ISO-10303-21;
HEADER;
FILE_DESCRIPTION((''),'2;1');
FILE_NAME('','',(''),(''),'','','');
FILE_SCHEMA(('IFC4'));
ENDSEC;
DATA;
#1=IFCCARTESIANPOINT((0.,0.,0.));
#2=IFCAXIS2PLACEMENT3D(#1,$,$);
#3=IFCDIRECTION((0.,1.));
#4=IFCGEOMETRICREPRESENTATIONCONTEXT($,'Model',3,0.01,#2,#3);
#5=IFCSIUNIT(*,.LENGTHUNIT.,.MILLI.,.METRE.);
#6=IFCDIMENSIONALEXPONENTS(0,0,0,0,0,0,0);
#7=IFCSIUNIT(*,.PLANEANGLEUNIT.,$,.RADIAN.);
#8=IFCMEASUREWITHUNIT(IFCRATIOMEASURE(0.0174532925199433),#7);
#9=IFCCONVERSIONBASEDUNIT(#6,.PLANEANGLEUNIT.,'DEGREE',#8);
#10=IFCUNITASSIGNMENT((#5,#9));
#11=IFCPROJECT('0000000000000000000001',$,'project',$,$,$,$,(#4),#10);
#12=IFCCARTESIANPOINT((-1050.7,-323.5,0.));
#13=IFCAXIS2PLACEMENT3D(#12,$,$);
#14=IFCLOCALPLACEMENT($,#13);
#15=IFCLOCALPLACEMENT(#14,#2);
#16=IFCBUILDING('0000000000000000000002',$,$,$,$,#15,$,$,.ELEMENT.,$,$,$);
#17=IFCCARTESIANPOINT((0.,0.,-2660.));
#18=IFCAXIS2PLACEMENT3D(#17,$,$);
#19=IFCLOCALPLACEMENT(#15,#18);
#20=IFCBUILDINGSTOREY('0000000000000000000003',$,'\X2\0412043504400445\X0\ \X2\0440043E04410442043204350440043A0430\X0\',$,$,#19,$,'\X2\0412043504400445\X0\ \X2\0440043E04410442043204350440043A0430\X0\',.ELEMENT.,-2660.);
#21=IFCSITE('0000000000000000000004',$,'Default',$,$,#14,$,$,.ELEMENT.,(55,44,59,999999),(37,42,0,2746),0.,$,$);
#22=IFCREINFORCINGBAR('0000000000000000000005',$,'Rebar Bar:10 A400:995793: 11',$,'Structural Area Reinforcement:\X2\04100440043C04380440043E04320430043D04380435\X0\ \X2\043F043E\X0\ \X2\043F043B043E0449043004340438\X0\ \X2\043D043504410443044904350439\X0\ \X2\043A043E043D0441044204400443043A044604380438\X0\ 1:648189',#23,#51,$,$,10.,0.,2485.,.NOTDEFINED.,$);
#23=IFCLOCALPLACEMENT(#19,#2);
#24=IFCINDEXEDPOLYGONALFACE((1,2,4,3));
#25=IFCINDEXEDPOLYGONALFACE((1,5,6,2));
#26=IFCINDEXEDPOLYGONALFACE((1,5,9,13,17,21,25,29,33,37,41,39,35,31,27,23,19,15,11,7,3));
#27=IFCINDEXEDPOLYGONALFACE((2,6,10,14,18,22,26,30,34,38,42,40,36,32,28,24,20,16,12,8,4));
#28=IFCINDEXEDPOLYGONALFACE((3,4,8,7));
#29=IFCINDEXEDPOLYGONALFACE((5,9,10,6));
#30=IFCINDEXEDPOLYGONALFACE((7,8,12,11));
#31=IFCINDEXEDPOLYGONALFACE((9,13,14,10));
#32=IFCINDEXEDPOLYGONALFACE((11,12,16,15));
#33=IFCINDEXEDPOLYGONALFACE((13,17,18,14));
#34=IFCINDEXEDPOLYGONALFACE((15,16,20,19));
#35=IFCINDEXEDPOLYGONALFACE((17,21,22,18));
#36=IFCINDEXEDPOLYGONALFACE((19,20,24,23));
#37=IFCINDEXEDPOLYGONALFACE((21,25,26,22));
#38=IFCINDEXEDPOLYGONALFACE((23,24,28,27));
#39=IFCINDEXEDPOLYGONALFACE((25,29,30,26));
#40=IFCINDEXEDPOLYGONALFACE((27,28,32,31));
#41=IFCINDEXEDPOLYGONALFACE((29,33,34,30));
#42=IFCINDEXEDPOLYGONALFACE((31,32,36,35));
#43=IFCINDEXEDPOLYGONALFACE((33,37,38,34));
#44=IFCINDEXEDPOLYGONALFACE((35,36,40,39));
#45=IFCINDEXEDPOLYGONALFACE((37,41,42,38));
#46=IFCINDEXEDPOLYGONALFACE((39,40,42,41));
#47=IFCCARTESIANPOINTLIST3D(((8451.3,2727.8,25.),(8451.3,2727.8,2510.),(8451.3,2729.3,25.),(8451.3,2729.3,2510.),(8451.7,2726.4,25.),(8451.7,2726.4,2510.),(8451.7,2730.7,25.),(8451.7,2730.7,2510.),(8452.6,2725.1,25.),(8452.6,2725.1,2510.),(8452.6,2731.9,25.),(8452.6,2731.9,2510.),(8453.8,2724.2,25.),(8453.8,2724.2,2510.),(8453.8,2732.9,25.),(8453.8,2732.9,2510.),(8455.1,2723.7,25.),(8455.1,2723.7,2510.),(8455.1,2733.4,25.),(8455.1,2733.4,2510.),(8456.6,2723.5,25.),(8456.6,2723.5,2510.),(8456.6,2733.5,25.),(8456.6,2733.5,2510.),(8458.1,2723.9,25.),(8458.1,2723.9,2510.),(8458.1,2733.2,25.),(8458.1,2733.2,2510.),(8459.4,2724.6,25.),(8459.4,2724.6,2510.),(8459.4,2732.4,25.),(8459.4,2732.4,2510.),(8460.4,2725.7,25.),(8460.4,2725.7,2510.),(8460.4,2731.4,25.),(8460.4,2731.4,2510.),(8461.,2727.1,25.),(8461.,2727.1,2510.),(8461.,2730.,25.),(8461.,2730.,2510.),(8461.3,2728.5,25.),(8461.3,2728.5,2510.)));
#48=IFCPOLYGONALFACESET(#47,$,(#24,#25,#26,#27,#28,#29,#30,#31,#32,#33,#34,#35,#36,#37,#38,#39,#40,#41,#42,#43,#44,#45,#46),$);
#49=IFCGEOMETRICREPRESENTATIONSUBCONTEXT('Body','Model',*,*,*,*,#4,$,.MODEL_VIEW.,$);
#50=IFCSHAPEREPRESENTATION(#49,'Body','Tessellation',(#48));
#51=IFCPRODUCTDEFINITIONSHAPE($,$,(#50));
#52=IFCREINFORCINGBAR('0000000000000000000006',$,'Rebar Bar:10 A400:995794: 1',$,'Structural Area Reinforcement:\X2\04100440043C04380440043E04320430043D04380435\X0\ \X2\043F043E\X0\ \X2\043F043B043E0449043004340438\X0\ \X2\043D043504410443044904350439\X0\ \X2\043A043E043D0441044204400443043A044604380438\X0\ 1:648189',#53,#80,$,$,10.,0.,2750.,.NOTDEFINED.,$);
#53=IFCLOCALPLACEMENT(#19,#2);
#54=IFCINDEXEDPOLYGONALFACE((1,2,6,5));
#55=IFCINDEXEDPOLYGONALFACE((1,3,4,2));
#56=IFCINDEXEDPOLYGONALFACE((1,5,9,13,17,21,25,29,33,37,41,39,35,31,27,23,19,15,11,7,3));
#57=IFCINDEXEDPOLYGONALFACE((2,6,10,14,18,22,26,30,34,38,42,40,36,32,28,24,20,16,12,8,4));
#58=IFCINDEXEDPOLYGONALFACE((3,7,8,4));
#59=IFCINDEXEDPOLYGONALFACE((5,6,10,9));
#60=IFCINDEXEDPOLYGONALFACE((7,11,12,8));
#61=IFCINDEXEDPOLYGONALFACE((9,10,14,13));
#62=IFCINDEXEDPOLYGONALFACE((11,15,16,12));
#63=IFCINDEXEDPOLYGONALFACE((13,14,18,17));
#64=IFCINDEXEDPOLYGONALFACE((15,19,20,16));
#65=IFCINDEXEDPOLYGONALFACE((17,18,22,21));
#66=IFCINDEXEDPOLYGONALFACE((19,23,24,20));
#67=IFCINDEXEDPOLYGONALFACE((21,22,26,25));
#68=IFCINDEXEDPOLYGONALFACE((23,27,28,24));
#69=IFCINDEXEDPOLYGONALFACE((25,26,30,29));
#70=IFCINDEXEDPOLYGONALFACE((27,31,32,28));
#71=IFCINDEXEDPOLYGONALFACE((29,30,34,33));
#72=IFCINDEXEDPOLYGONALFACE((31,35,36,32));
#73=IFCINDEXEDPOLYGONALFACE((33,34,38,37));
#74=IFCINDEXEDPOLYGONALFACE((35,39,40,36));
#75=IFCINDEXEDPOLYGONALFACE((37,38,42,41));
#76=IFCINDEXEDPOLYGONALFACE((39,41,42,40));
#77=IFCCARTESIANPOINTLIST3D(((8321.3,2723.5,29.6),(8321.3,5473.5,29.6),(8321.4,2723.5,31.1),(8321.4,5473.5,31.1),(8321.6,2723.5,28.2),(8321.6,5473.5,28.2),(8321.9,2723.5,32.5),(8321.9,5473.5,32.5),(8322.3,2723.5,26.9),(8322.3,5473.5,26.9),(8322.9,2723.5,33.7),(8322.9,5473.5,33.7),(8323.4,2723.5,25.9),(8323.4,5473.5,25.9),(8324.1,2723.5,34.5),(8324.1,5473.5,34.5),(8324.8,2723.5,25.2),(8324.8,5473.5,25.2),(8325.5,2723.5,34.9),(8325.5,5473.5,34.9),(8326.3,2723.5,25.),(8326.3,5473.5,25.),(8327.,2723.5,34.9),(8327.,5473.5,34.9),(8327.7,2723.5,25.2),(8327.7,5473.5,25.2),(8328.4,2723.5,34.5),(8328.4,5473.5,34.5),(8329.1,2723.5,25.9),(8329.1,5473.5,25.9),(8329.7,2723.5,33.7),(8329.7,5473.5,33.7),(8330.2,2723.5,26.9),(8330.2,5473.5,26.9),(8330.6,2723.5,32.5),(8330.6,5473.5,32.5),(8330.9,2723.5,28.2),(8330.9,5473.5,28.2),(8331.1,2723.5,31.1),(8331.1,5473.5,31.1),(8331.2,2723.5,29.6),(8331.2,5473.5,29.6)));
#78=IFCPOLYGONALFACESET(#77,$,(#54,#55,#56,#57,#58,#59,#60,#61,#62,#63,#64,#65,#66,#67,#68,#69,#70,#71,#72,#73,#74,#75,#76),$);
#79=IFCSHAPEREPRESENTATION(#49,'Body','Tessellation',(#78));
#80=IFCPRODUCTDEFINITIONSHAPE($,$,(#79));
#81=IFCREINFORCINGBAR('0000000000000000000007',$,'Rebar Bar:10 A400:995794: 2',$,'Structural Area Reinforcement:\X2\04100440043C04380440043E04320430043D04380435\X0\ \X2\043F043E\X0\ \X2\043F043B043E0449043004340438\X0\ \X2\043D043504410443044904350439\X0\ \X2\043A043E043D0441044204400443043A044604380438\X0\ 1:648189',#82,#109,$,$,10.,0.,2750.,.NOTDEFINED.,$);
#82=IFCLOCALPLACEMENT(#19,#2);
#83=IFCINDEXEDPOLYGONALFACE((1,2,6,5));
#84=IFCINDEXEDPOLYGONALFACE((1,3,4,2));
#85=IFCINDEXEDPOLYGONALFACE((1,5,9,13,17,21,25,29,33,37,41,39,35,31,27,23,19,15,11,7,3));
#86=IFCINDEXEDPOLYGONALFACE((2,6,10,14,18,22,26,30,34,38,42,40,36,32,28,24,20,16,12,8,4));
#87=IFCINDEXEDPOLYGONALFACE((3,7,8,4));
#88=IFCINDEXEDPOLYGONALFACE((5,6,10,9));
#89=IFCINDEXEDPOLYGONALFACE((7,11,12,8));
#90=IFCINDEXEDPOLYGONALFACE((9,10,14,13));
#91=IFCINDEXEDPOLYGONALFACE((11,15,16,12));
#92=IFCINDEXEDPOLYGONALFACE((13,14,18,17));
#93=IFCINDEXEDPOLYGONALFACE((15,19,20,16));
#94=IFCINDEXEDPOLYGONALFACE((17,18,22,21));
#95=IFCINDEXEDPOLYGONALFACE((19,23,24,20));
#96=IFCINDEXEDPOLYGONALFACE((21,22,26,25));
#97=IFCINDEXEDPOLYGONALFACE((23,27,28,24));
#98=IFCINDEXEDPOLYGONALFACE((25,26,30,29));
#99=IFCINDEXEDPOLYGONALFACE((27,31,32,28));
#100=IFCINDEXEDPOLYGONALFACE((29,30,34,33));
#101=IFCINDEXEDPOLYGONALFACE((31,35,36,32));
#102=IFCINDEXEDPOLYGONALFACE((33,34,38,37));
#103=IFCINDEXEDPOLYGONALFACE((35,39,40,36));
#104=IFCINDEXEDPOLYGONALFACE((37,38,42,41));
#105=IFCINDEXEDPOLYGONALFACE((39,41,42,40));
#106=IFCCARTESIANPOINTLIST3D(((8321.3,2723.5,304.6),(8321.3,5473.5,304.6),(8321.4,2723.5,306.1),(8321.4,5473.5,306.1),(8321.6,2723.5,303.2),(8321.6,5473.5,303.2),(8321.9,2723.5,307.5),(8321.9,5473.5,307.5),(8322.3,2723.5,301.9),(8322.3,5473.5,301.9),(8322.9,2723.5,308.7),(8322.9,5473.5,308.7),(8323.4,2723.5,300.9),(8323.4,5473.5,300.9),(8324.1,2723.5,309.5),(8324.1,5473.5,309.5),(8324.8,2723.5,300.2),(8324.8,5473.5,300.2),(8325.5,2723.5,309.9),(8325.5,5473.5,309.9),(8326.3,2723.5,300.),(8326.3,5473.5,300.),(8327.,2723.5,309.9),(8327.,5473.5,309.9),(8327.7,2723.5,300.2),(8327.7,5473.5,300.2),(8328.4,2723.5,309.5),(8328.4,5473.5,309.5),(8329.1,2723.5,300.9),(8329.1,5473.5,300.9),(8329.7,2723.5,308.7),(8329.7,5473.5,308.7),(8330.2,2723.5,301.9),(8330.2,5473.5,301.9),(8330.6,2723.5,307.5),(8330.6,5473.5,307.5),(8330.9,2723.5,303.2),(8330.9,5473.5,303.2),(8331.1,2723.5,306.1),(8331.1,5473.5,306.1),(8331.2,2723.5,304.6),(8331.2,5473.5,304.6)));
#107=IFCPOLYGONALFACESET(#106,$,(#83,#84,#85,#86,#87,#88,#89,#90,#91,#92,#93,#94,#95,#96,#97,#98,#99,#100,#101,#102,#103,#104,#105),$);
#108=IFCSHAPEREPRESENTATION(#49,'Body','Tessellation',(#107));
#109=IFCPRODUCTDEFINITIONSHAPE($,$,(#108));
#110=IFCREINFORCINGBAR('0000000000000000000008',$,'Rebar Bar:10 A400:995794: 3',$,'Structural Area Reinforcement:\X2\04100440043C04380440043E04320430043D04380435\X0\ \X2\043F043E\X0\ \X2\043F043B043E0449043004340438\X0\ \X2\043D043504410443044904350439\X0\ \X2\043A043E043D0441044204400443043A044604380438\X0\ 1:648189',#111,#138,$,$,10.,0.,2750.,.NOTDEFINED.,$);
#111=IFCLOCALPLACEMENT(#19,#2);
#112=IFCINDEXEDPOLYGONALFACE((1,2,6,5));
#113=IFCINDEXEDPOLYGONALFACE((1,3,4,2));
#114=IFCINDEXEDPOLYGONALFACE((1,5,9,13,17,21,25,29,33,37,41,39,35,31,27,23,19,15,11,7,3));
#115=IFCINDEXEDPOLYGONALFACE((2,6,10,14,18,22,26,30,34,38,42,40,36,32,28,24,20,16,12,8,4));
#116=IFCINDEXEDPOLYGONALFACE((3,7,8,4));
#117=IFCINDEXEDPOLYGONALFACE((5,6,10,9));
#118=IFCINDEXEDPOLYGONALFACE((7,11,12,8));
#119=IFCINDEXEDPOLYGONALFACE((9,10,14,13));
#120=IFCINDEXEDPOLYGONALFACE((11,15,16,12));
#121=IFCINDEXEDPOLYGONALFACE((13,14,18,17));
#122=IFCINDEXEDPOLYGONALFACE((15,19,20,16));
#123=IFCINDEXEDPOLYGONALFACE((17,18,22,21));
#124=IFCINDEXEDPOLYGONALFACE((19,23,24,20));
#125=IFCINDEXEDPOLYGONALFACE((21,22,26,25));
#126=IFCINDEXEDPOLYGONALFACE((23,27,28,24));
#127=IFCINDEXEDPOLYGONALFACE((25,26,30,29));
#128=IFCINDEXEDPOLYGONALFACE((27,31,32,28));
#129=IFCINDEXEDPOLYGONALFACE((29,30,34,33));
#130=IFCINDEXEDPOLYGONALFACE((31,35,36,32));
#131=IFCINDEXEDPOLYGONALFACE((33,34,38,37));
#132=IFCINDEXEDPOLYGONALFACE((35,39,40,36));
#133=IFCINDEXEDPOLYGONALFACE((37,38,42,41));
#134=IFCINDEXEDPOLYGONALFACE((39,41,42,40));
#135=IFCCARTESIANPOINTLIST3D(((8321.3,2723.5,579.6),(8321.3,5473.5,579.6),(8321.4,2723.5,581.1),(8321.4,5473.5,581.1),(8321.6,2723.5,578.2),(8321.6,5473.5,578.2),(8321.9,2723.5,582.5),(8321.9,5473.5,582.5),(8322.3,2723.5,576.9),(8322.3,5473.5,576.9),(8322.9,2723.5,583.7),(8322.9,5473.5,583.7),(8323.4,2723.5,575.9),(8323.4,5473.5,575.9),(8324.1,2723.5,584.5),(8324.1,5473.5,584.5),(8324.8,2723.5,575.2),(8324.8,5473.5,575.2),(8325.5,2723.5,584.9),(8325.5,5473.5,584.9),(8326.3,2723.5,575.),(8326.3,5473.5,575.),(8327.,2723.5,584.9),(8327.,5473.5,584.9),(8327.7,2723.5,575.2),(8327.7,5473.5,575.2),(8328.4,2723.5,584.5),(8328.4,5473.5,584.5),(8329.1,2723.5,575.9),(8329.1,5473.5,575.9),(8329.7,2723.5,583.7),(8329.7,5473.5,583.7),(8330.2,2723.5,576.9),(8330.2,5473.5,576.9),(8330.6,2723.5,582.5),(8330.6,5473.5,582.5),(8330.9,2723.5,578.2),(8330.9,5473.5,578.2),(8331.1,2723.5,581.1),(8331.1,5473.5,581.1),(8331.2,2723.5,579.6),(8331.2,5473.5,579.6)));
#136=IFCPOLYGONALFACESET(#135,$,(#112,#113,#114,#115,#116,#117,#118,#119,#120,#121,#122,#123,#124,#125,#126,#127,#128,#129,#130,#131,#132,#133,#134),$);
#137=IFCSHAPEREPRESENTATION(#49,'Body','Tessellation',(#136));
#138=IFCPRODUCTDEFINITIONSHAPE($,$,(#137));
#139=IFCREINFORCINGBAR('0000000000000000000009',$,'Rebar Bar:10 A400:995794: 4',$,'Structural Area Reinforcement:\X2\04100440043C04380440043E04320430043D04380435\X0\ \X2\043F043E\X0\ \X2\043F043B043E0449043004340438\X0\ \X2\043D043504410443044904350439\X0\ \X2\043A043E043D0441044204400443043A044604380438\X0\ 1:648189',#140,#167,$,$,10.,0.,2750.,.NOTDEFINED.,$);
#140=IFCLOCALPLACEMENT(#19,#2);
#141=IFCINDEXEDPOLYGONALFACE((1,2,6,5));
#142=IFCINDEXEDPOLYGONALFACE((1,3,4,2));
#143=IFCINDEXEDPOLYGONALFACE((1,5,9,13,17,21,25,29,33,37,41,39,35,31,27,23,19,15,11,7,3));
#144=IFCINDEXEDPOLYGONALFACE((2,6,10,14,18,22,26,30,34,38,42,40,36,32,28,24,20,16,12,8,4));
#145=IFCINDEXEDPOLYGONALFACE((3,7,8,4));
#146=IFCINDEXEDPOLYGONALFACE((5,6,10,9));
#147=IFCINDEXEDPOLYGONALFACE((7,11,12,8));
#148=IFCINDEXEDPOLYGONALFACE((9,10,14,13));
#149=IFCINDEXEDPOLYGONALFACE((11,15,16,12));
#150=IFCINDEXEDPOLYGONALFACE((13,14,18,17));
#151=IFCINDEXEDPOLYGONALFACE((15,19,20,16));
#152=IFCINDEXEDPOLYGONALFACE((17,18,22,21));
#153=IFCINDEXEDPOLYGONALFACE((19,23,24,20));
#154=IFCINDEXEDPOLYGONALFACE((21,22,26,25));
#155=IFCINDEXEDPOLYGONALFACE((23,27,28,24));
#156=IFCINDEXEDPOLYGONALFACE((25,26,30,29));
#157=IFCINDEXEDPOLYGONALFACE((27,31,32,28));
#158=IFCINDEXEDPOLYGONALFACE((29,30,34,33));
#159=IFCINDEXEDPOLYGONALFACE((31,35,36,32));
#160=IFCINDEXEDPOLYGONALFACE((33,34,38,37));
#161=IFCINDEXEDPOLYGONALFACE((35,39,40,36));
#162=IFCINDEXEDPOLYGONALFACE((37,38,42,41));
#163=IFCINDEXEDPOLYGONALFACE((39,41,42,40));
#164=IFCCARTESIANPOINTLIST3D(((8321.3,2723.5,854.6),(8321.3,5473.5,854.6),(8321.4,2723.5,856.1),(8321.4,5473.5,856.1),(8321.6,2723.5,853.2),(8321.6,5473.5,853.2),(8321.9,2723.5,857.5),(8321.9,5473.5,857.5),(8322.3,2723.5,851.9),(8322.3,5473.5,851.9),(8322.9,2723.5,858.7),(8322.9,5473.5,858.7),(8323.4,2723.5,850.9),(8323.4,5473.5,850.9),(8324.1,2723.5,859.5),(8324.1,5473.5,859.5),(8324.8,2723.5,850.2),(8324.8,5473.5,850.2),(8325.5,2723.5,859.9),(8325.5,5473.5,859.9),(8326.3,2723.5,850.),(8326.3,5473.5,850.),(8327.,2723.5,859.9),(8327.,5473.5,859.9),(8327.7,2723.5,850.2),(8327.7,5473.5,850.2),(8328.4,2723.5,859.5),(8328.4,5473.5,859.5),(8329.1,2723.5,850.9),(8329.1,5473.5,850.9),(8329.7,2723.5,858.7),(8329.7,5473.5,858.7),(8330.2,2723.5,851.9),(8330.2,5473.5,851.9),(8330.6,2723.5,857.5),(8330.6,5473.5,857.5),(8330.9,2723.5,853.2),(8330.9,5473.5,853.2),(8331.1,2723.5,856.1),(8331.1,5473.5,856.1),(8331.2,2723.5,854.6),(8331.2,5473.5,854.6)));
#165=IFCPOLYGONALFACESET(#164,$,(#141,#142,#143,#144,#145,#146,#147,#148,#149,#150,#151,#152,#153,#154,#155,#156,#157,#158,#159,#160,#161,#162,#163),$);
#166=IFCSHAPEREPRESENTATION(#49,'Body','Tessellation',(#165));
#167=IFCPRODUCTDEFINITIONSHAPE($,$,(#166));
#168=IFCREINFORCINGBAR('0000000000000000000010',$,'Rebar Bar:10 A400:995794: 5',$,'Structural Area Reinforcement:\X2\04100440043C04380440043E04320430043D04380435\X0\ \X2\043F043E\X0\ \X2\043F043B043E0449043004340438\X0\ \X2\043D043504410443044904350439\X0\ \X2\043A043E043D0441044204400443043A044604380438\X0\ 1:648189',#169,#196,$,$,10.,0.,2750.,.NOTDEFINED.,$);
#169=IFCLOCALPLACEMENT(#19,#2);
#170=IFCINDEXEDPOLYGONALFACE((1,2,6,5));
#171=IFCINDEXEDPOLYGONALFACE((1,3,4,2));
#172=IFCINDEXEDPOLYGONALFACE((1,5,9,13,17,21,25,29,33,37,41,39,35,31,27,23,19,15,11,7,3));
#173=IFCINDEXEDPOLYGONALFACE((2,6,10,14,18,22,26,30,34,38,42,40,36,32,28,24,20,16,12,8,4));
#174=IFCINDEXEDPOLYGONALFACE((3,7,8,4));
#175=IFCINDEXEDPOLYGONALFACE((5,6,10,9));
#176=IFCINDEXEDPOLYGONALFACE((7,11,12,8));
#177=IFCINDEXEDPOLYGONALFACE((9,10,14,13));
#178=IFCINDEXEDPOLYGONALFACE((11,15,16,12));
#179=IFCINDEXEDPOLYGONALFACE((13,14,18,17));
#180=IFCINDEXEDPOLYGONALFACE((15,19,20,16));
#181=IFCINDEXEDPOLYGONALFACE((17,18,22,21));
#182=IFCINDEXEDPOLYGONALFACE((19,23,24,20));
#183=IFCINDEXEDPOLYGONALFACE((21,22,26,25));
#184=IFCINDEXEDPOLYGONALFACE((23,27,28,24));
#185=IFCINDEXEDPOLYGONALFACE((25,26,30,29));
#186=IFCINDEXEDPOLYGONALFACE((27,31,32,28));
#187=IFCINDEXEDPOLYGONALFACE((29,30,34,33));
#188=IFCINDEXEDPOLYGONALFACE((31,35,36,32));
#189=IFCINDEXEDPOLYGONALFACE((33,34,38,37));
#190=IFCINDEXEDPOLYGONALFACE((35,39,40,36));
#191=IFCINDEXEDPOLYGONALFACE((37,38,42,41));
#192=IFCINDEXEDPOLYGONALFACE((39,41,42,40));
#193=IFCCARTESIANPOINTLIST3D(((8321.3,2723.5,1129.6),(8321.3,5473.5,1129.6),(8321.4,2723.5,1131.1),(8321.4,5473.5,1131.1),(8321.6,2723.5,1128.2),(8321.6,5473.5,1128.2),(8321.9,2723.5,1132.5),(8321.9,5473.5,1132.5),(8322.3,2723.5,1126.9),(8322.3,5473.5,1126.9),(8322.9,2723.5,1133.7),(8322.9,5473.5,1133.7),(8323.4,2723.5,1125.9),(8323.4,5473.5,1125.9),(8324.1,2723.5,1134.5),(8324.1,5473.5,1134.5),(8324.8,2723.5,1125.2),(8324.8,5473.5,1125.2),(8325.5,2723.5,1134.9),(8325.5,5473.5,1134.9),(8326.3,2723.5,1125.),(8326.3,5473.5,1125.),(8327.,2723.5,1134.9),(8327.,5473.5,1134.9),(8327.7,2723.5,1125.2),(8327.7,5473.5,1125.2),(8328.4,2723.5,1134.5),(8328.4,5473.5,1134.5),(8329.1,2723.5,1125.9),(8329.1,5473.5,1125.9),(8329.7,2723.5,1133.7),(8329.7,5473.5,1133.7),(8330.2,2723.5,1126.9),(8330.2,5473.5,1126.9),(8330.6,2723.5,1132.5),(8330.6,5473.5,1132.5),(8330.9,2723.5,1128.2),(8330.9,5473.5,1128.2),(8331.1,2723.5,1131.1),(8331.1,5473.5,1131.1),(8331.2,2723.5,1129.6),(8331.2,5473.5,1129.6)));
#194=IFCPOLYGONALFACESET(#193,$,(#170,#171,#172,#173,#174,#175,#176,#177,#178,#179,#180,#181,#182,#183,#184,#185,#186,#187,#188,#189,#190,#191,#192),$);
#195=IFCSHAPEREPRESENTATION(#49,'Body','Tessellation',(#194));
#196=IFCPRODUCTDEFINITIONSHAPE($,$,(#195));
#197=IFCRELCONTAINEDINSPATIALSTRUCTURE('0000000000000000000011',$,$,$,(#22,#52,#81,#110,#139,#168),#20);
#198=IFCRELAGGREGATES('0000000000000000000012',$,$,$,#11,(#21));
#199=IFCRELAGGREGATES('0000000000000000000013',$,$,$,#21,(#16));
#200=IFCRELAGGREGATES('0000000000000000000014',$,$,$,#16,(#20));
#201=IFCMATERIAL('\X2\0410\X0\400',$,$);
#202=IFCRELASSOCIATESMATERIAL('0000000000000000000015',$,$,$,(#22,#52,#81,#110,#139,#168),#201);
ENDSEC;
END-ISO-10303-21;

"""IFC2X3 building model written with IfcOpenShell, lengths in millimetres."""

from ifc_helpers import new_model, entity, si_unit, converted_unit, direction, frame, origin, place, context, subcontext, project, spatial, material, element, save


model = new_model("IFC2X3")

# Units and contexts
model_context = context("Model", 3, precision=0.01, world=origin(), true_north=direction((0.0, 1.0)))
body_context = subcontext(model_context, "Body", "Model", "MODEL_VIEW")
ifc_project = project(units=[si_unit("LENGTHUNIT", "METRE", prefix="MILLI"), converted_unit("PLANEANGLEUNIT", "DEGREE", entity("IfcRatioMeasure", 0.0174532925199433), si_unit("PLANEANGLEUNIT", "RADIAN"), dimensions=[0, 0, 0, 0, 0, 0, 0])], contexts=[model_context])

# Site, building, storey
site_placement = place(None, frame((-1050.7, -323.5, 0.0)))
site = spatial("IfcSite", under=ifc_project, at=site_placement, Name="Default", CompositionType="ELEMENT", RefLatitude=(55, 44, 59, 999999), RefLongitude=(37, 42, 0, 2746), RefElevation=0.0)
building_placement = place(site_placement, origin())
building = spatial("IfcBuilding", under=site, at=building_placement, CompositionType="ELEMENT")
storey_placement = place(building_placement, frame((0.0, 0.0, -2660.0)))
storey = spatial("IfcBuildingStorey", under=building, at=storey_placement, Name="Верх ростверка", LongName="Верх ростверка", CompositionType="ELEMENT", Elevation=-2660.0)

# Reinforcing bars
ifc_material = material(Name="А400")
reinforcing_bar_1_placement = place(storey_placement, origin())
element("IfcReinforcingBar", 1, at=reinforcing_bar_1_placement, inside=storey, material=ifc_material, Name="Rebar Bar:10 A400:995793: 11", ObjectType="Structural Area Reinforcement:Армирование по площади несущей конструкции 1:648189", BarLength=2485.0, BarRole="NOTDEFINED", CrossSectionArea=0.0, NominalDiameter=10.0, context=body_context, shape_type="AdvancedSweptSolid", body=[
    entity("IfcSweptDiskSolid", entity("IfcCompositeCurve", [entity("IfcCompositeCurveSegment", "CONTINUOUS", True, entity("IfcPolyline", [entity("IfcCartesianPoint", [8456.3, 2728.5, 25.0]), entity("IfcCartesianPoint", [8456.3, 2728.5, 2510.0])]))], False), 5.0, None, 0.0, 1.0),
])
reinforcing_bar_2_placement = place(storey_placement, origin())
element("IfcReinforcingBar", 2, at=reinforcing_bar_2_placement, inside=storey, material=ifc_material, Name="Rebar Bar:10 A400:995794: 1", ObjectType="Structural Area Reinforcement:Армирование по площади несущей конструкции 1:648189", BarLength=2750.0, BarRole="NOTDEFINED", CrossSectionArea=0.0, NominalDiameter=10.0, context=body_context, shape_type="AdvancedSweptSolid", body=[
    entity("IfcSweptDiskSolid", entity("IfcCompositeCurve", [entity("IfcCompositeCurveSegment", "CONTINUOUS", True, entity("IfcPolyline", [entity("IfcCartesianPoint", [8326.3, 5473.5, 30.0]), entity("IfcCartesianPoint", [8326.3, 2723.5, 30.0])]))], False), 5.0, None, 0.0, 1.0),
])
reinforcing_bar_3_placement = place(storey_placement, origin())
element("IfcReinforcingBar", 3, at=reinforcing_bar_3_placement, inside=storey, material=ifc_material, Name="Rebar Bar:10 A400:995794: 2", ObjectType="Structural Area Reinforcement:Армирование по площади несущей конструкции 1:648189", BarLength=2750.0, BarRole="NOTDEFINED", CrossSectionArea=0.0, NominalDiameter=10.0, context=body_context, shape_type="AdvancedSweptSolid", body=[
    entity("IfcSweptDiskSolid", entity("IfcCompositeCurve", [entity("IfcCompositeCurveSegment", "CONTINUOUS", True, entity("IfcPolyline", [entity("IfcCartesianPoint", [8326.3, 5473.5, 305.0]), entity("IfcCartesianPoint", [8326.3, 2723.5, 305.0])]))], False), 5.0, None, 0.0, 1.0),
])
reinforcing_bar_4_placement = place(storey_placement, origin())
element("IfcReinforcingBar", 4, at=reinforcing_bar_4_placement, inside=storey, material=ifc_material, Name="Rebar Bar:10 A400:995794: 3", ObjectType="Structural Area Reinforcement:Армирование по площади несущей конструкции 1:648189", BarLength=2750.0, BarRole="NOTDEFINED", CrossSectionArea=0.0, NominalDiameter=10.0, context=body_context, shape_type="AdvancedSweptSolid", body=[
    entity("IfcSweptDiskSolid", entity("IfcCompositeCurve", [entity("IfcCompositeCurveSegment", "CONTINUOUS", True, entity("IfcPolyline", [entity("IfcCartesianPoint", [8326.3, 5473.5, 580.0]), entity("IfcCartesianPoint", [8326.3, 2723.5, 580.0])]))], False), 5.0, None, 0.0, 1.0),
])
reinforcing_bar_5_placement = place(storey_placement, origin())
element("IfcReinforcingBar", 5, at=reinforcing_bar_5_placement, inside=storey, material=ifc_material, Name="Rebar Bar:10 A400:995794: 4", ObjectType="Structural Area Reinforcement:Армирование по площади несущей конструкции 1:648189", BarLength=2750.0, BarRole="NOTDEFINED", CrossSectionArea=0.0, NominalDiameter=10.0, context=body_context, shape_type="AdvancedSweptSolid", body=[
    entity("IfcSweptDiskSolid", entity("IfcCompositeCurve", [entity("IfcCompositeCurveSegment", "CONTINUOUS", True, entity("IfcPolyline", [entity("IfcCartesianPoint", [8326.3, 5473.5, 855.0]), entity("IfcCartesianPoint", [8326.3, 2723.5, 855.0])]))], False), 5.0, None, 0.0, 1.0),
])
reinforcing_bar_6_placement = place(storey_placement, origin())
element("IfcReinforcingBar", 6, at=reinforcing_bar_6_placement, inside=storey, material=ifc_material, Name="Rebar Bar:10 A400:995794: 5", ObjectType="Structural Area Reinforcement:Армирование по площади несущей конструкции 1:648189", BarLength=2750.0, BarRole="NOTDEFINED", CrossSectionArea=0.0, NominalDiameter=10.0, context=body_context, shape_type="AdvancedSweptSolid", body=[
    entity("IfcSweptDiskSolid", entity("IfcCompositeCurve", [entity("IfcCompositeCurveSegment", "CONTINUOUS", True, entity("IfcPolyline", [entity("IfcCartesianPoint", [8326.3, 5473.5, 1130.0]), entity("IfcCartesianPoint", [8326.3, 2723.5, 1130.0])]))], False), 5.0, None, 0.0, 1.0),
])

save(model, "model.ifc")
